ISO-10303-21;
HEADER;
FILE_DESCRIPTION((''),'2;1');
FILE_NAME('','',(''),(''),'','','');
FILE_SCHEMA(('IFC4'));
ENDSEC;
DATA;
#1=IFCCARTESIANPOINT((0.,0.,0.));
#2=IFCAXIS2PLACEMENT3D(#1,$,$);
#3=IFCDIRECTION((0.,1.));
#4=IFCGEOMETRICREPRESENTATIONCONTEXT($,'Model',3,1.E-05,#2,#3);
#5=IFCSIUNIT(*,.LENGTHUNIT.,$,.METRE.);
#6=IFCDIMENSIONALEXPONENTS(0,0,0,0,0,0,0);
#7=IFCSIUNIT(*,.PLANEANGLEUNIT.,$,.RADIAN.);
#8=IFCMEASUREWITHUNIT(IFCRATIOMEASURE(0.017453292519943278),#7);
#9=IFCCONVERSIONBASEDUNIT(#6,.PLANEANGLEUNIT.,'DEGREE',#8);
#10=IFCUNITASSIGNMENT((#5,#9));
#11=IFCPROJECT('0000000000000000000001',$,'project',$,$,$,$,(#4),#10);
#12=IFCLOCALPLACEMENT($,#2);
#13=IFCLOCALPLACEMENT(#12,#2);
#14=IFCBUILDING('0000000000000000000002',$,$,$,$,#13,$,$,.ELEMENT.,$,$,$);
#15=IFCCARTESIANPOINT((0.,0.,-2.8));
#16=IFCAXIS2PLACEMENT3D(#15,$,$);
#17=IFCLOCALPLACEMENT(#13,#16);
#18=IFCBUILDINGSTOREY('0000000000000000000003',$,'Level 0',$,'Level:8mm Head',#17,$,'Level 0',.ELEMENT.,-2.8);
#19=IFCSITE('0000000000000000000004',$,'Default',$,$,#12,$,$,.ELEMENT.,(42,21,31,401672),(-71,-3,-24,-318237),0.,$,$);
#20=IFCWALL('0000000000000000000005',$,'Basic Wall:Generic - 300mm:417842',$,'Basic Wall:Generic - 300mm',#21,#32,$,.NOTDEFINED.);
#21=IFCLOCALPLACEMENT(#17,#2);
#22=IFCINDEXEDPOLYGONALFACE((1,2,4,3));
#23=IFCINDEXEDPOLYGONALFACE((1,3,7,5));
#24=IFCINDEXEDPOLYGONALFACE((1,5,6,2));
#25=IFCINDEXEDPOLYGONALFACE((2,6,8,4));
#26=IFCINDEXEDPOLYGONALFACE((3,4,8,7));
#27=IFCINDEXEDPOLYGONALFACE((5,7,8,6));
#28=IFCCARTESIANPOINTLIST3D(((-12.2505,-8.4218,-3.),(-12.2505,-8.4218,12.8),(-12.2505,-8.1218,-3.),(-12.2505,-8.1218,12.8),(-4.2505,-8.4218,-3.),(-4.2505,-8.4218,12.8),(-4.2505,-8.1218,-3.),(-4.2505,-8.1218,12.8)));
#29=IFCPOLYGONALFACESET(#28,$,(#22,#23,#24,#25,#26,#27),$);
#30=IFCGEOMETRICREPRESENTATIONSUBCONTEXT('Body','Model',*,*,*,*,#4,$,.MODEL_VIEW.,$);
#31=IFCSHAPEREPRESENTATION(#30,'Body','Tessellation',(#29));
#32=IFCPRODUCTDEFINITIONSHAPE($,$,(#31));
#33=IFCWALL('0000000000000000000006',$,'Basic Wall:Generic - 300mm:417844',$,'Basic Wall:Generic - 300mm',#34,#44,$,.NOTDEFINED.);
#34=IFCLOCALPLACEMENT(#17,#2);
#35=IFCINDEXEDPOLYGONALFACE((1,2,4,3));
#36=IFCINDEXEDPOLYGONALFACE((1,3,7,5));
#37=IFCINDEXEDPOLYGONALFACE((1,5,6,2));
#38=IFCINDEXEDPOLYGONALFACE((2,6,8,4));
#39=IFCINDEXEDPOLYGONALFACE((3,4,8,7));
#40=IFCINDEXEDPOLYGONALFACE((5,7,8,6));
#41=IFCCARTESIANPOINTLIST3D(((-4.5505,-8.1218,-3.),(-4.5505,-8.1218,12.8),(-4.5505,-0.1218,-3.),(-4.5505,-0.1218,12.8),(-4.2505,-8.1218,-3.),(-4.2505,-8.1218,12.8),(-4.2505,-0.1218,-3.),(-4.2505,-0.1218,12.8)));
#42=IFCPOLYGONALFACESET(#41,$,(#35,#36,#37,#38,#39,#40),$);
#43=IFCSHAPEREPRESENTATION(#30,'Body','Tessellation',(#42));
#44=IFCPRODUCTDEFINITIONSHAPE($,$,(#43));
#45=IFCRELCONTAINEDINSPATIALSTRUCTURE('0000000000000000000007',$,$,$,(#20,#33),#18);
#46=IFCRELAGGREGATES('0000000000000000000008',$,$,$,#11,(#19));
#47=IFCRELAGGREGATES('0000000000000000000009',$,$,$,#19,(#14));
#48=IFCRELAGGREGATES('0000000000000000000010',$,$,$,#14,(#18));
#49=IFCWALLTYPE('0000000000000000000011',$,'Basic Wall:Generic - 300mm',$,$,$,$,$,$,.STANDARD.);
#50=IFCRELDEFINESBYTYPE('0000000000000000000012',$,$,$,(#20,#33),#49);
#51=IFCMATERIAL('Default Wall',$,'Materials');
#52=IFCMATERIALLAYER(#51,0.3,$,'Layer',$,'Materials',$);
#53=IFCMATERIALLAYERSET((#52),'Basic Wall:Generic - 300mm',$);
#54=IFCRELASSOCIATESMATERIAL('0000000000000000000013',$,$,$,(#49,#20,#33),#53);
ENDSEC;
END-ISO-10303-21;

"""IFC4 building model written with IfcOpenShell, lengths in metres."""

from ifc_helpers import new_model, entity, si_unit, converted_unit, direction, frame, frame_2d, origin, place, context, subcontext, project, spatial, rectangle, extrude, material, layer, layer_set, layer_usage, type_object, element, save


model = new_model("IFC4")

# Units and contexts
model_context = context("Model", 3, precision=1e-05, world=origin(), true_north=direction((0.0, 1.0)))
body_context = subcontext(model_context, "Body", "Model", "MODEL_VIEW")
ifc_project = project(units=[si_unit("LENGTHUNIT", "METRE"), converted_unit("PLANEANGLEUNIT", "DEGREE", entity("IfcRatioMeasure", 0.017453292519943278), si_unit("PLANEANGLEUNIT", "RADIAN"), dimensions=[0, 0, 0, 0, 0, 0, 0])], contexts=[model_context])

# Site, building, storey
site_placement = place(None, origin())
site = spatial("IfcSite", under=ifc_project, at=site_placement, Name="Default", CompositionType="ELEMENT", RefLatitude=(42, 21, 31, 401672), RefLongitude=(-71, -3, -24, -318237), RefElevation=0.0)
building_placement = place(site_placement, origin())
building = spatial("IfcBuilding", under=site, at=building_placement, CompositionType="ELEMENT")
storey_placement = place(building_placement, frame((0.0, 0.0, -2.8)))
storey = spatial("IfcBuildingStorey", under=building, at=storey_placement, Name="Level 0", ObjectType="Level:8mm Head", LongName="Level 0", CompositionType="ELEMENT", Elevation=-2.8)

# Walls
ifc_material_1 = material(Name="Default Wall", Category="Materials")
ifc_layer = layer(ifc_material_1, 0.3, Name="Layer", Category="Materials")
ifc_layer_set = layer_set([ifc_layer], Name="Basic Wall:Generic - 300mm")
ifc_layer_usage = layer_usage(ifc_layer_set, "AXIS2", "NEGATIVE", 0.15)
wall_type = type_object("IfcWallType", Name="Basic Wall:Generic - 300mm", PredefinedType="STANDARD", material=ifc_layer_set)
wall_1_placement = place(storey_placement, frame((-4.2505, -8.2718, -3.0), z_axis=(0.0, 0.0, 1.0), x_axis=(-1.0, 0.0, 0.0)))
element("IfcWall", 1, at=wall_1_placement, inside=storey, type_object=wall_type, material=ifc_layer_usage, Name="Basic Wall:Generic - 300mm:417842", ObjectType="Basic Wall:Generic - 300mm", PredefinedType="NOTDEFINED", context=body_context, shape_type="SweptSolid", body=[
    extrude(rectangle(XDim=8.0, YDim=0.3, at=frame_2d((4.0, 0.0), x_axis=(-1.0, 0.0))), origin(), (0.0, 0.0, 1.0), 15.8),
])
wall_2_placement = place(storey_placement, frame((-4.4005, -0.1218, -3.0), z_axis=(0.0, 0.0, 1.0), x_axis=(0.0, -1.0, 0.0)))
element("IfcWall", 2, at=wall_2_placement, inside=storey, type_object=wall_type, material=ifc_layer_usage, Name="Basic Wall:Generic - 300mm:417844", ObjectType="Basic Wall:Generic - 300mm", PredefinedType="NOTDEFINED", context=body_context, shape_type="SweptSolid", body=[
    extrude(rectangle(XDim=8.0, YDim=0.3, at=frame_2d((4.0, 0.0), x_axis=(-1.0, 0.0))), origin(), (0.0, 0.0, 1.0), 15.8),
])

save(model, "model.ifc")
